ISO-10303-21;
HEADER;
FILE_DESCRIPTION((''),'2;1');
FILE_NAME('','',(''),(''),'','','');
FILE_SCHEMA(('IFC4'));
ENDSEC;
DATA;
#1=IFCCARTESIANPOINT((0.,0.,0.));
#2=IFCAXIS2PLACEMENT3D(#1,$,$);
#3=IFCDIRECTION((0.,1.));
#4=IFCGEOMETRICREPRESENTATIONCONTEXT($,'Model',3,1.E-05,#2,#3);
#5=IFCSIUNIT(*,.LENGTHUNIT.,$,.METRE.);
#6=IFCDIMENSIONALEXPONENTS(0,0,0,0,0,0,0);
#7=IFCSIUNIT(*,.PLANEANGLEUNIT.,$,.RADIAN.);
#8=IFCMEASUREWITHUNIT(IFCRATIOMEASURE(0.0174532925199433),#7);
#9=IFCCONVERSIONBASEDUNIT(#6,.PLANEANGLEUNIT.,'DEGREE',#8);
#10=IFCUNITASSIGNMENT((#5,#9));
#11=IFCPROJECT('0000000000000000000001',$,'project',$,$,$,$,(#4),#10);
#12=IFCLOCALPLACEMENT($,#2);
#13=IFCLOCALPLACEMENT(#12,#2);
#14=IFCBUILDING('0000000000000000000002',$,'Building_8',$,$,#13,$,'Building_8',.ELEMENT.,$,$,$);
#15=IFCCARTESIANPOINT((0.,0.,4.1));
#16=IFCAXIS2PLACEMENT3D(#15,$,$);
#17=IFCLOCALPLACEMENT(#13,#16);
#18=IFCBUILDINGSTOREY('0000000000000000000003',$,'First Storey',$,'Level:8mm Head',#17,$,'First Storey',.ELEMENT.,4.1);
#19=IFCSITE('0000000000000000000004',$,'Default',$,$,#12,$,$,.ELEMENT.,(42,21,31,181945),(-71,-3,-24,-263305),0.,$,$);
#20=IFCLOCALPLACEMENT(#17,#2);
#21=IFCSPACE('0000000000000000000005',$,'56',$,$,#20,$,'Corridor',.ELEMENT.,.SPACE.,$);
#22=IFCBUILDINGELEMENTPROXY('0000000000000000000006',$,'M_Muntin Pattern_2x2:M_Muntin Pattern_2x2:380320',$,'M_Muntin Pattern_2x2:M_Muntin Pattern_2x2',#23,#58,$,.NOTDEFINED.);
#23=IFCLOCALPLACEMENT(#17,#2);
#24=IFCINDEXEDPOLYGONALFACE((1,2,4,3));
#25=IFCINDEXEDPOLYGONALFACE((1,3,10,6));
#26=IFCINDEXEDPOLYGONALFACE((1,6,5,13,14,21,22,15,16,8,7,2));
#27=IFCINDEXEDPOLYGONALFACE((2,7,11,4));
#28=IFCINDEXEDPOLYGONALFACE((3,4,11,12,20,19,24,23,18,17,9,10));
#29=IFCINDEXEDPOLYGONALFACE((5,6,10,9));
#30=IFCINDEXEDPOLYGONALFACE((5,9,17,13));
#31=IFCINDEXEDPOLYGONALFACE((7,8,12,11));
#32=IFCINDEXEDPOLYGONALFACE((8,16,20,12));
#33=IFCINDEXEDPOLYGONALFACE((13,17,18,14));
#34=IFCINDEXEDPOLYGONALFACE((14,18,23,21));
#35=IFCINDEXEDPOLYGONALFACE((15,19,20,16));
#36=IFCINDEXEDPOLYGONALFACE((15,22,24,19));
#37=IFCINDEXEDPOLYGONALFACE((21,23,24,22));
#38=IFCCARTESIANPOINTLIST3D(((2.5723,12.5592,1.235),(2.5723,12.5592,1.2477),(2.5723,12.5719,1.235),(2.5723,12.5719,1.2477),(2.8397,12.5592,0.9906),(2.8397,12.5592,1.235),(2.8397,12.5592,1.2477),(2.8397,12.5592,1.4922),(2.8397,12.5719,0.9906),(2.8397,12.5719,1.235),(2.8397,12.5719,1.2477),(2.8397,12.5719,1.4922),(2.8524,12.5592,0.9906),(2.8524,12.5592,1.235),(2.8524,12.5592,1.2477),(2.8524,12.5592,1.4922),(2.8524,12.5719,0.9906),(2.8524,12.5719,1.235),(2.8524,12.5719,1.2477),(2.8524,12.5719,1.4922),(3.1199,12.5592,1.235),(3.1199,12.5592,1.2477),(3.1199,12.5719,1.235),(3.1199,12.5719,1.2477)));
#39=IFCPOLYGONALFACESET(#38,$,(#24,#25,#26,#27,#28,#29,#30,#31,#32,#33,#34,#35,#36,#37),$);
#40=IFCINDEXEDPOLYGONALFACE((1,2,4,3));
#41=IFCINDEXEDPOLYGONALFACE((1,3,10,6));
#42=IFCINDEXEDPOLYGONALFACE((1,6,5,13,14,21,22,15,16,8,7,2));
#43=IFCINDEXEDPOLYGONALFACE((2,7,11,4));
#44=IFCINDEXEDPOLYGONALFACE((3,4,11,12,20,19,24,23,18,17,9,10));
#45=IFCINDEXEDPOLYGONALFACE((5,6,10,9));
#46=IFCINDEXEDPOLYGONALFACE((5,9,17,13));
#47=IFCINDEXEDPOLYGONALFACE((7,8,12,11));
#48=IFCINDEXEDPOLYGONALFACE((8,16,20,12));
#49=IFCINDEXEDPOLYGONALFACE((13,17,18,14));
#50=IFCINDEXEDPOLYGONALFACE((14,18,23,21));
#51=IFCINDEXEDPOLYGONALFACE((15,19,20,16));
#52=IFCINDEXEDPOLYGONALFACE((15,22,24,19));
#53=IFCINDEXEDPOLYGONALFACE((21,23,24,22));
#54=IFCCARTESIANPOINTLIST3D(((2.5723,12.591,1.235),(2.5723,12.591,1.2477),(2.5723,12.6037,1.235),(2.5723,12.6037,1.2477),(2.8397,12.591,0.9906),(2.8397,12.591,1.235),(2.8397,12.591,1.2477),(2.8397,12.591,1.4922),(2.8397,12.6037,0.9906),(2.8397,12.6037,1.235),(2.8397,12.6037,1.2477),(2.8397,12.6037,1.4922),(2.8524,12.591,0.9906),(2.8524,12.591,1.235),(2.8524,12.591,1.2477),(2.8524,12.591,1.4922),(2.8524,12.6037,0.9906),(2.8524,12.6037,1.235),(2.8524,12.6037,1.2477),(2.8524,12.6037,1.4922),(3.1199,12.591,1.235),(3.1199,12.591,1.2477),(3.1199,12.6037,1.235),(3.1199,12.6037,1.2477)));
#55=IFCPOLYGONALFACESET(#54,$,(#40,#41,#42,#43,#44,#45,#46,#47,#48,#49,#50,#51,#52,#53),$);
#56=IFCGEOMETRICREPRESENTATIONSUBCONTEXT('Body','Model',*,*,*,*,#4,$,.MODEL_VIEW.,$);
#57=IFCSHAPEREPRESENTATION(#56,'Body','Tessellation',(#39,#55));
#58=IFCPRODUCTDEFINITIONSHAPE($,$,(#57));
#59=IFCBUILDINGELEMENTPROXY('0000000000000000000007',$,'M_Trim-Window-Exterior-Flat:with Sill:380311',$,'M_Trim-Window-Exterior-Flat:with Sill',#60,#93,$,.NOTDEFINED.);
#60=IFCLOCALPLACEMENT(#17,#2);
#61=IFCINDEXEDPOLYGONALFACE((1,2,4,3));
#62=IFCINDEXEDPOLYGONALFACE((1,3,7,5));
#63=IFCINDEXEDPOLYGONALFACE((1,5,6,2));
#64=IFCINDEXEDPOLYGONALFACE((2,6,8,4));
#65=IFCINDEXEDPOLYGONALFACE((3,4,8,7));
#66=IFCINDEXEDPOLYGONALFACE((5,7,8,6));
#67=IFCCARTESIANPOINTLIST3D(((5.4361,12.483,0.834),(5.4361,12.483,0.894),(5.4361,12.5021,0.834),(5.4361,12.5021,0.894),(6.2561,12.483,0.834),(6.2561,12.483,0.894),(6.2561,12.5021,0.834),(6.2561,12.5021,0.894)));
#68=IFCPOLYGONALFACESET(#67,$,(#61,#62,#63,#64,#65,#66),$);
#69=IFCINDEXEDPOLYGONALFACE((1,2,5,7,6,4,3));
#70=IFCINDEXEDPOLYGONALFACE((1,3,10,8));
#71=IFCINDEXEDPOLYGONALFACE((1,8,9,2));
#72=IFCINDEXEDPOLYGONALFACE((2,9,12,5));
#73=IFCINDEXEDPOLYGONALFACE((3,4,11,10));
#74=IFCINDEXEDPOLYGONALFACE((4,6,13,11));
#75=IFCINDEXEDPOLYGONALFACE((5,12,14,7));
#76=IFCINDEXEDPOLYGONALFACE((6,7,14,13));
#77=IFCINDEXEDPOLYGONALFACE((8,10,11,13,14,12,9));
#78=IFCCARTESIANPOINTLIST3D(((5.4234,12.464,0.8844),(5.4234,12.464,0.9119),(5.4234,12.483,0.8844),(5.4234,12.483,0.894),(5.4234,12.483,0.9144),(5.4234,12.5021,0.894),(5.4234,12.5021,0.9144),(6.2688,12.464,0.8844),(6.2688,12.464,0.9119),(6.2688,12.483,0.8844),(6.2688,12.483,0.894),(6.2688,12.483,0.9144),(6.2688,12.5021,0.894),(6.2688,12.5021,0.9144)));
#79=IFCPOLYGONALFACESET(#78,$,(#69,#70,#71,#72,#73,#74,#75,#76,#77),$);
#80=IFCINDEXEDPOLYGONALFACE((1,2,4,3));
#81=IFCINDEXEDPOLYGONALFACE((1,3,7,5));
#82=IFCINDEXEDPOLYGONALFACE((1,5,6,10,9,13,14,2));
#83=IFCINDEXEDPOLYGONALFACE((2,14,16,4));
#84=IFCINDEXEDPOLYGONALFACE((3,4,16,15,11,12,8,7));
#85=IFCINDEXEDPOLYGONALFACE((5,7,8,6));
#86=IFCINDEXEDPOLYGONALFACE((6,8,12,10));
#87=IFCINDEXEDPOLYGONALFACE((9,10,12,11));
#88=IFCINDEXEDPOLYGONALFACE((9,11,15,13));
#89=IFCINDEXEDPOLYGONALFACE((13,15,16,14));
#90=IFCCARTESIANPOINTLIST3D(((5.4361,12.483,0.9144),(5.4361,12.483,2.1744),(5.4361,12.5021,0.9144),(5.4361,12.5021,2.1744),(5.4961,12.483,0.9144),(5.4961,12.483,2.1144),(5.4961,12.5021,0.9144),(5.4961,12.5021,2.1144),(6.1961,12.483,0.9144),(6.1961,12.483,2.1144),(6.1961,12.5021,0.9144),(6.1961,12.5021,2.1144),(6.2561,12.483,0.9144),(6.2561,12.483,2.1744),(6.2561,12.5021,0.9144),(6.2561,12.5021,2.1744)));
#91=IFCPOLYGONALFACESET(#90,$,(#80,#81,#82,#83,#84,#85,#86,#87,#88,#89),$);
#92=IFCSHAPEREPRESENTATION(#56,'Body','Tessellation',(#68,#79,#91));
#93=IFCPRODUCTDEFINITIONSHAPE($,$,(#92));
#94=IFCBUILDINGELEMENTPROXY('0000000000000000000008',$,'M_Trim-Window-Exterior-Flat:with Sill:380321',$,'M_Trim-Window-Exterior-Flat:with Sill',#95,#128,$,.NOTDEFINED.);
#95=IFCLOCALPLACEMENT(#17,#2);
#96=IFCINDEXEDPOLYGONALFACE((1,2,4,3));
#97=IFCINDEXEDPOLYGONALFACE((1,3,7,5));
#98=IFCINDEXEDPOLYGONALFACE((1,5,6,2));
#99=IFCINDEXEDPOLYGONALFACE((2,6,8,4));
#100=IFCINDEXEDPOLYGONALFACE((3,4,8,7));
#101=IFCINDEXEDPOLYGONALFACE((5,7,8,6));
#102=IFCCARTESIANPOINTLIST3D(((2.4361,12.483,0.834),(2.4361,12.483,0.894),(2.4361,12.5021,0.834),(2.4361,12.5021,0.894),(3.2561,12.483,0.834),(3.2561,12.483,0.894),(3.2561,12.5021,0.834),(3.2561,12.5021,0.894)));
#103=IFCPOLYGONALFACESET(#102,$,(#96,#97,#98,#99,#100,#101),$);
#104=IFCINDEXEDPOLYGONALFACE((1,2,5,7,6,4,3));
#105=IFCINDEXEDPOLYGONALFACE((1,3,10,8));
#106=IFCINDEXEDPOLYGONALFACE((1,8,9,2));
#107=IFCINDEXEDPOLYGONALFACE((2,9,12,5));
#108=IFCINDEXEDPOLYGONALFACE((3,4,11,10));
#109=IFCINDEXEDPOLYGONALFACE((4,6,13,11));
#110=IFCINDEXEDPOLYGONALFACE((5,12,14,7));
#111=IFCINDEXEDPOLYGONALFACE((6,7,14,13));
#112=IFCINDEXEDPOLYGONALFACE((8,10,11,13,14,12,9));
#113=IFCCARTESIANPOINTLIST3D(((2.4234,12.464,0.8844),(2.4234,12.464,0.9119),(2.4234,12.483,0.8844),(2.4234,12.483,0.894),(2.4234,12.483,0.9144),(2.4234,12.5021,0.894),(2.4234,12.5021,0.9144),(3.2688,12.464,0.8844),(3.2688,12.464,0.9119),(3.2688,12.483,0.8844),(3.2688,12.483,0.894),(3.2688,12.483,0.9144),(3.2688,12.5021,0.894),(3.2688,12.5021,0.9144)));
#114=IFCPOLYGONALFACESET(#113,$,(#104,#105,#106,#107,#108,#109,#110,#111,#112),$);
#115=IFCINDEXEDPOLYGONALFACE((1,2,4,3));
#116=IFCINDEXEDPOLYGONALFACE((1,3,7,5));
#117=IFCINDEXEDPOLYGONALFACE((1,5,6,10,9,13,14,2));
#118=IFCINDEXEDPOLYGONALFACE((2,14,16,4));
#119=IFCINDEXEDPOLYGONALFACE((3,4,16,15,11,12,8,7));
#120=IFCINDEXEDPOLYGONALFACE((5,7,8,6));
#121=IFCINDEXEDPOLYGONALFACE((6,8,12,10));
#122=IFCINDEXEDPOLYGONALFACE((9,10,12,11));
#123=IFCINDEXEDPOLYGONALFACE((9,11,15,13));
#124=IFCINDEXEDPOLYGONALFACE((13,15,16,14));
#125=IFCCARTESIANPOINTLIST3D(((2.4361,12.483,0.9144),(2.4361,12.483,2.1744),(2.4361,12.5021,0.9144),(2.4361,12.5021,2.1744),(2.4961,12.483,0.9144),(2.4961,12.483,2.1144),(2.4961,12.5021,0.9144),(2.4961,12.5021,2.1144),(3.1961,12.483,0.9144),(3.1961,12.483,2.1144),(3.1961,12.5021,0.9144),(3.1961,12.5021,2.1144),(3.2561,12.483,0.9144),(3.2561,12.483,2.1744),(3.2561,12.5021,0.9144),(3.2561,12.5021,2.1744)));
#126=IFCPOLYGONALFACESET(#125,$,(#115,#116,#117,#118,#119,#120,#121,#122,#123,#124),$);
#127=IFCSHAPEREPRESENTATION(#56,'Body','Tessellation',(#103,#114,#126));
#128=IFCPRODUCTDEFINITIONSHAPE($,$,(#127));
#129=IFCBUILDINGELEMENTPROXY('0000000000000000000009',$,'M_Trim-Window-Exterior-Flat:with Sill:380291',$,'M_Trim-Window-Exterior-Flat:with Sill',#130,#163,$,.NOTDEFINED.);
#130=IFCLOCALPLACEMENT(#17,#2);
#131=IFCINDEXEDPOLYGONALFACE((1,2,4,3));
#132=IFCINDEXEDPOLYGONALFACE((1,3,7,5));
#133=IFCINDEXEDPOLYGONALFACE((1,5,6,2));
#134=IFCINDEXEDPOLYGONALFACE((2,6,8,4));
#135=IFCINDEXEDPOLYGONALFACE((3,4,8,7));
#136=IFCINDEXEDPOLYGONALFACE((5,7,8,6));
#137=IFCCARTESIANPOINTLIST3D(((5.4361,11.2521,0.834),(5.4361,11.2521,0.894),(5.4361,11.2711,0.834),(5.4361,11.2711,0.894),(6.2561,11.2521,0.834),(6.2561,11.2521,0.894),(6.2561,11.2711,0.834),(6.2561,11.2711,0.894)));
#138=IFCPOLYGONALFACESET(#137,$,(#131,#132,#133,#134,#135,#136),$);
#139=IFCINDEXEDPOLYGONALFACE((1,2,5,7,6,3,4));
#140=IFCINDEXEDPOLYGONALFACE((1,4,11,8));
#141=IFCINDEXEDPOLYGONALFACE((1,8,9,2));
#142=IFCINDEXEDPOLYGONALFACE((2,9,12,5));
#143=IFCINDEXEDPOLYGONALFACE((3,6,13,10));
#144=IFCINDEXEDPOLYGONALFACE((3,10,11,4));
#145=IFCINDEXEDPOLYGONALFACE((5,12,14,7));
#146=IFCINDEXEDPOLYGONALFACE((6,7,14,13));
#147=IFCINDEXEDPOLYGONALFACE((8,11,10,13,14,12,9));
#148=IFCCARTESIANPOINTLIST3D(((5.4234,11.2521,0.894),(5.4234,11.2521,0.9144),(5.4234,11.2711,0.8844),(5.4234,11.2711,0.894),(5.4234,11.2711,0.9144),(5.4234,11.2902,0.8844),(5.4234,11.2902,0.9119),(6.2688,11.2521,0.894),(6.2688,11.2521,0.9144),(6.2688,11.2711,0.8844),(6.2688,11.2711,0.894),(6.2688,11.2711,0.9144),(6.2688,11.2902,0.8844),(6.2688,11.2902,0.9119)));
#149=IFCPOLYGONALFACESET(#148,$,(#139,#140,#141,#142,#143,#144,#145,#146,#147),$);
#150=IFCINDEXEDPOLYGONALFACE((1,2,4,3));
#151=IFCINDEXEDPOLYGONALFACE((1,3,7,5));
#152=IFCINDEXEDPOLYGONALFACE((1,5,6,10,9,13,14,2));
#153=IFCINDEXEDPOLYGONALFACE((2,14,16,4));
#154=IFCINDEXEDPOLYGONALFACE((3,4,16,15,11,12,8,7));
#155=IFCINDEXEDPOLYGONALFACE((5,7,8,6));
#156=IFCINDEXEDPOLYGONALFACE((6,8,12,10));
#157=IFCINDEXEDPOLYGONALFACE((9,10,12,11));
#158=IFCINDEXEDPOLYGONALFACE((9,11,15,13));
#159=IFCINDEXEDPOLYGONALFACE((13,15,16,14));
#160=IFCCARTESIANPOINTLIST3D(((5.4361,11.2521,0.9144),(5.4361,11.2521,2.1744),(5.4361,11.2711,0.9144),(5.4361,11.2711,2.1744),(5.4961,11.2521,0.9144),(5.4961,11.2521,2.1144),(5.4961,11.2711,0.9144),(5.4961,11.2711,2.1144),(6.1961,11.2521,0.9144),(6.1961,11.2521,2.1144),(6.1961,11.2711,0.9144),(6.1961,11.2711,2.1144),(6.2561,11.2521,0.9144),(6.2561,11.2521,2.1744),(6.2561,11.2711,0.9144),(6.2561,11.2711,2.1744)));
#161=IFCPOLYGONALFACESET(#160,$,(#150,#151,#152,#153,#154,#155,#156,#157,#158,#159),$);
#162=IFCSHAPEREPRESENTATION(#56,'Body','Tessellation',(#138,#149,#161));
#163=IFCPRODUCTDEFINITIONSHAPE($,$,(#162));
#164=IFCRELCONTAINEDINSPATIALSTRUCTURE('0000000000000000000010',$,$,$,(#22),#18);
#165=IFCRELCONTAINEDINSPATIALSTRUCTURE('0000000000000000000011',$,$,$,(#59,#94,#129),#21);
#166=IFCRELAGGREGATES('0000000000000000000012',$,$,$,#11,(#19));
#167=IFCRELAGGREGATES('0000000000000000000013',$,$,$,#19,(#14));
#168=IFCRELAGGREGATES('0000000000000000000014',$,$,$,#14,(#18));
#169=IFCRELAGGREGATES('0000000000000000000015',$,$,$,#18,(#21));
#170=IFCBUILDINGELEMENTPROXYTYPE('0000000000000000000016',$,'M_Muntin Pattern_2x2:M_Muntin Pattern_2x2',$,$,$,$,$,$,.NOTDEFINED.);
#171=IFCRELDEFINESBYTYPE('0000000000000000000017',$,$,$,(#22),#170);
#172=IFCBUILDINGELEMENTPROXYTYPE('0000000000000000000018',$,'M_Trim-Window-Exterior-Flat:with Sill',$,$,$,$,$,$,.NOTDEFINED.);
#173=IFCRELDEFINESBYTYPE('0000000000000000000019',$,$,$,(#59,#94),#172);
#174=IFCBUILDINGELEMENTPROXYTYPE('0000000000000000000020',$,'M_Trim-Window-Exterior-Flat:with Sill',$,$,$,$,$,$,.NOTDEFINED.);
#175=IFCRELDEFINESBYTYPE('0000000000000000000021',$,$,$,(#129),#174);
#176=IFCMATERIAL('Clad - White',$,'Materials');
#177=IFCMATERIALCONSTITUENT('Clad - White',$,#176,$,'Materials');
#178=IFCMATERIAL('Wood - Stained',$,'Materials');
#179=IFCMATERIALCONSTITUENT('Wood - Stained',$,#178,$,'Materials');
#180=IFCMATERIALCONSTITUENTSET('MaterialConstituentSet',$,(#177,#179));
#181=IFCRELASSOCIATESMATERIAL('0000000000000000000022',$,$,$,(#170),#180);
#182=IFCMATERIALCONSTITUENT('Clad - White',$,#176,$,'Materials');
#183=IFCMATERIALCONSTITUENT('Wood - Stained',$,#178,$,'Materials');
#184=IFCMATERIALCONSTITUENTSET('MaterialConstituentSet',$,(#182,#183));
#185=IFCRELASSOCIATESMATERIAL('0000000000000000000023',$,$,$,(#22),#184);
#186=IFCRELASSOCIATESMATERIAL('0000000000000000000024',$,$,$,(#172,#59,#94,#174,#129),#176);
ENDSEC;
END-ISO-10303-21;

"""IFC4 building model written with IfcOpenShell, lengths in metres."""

from ifc_helpers import new_model, entity, si_unit, converted_unit, direction, frame, origin, place, context, subcontext, project, spatial, indexed_curve, outline, extrude, source, transform, mapped, material, constituent, constituent_set, type_object, type_shapes, element, save


model = new_model("IFC4")

# Units and contexts
model_context = context("Model", 3, precision=1e-05, world=origin(), true_north=direction((0.0, 1.0)))
body_context = subcontext(model_context, "Body", "Model", "MODEL_VIEW")
ifc_project = project(units=[si_unit("LENGTHUNIT", "METRE"), converted_unit("PLANEANGLEUNIT", "DEGREE", entity("IfcRatioMeasure", 0.0174532925199433), si_unit("PLANEANGLEUNIT", "RADIAN"), dimensions=[0, 0, 0, 0, 0, 0, 0])], contexts=[model_context])

# Site, building, storey
site_placement = place(None, origin())
site = spatial("IfcSite", under=ifc_project, at=site_placement, Name="Default", CompositionType="ELEMENT", RefLatitude=(42, 21, 31, 181945), RefLongitude=(-71, -3, -24, -263305), RefElevation=0.0)
building_placement = place(site_placement, origin())
building = spatial("IfcBuilding", under=site, at=building_placement, Name="Building_8", LongName="Building_8", CompositionType="ELEMENT")
storey_placement = place(building_placement, frame((0.0, 0.0, 4.1)))
storey = spatial("IfcBuildingStorey", under=building, at=storey_placement, Name="First Storey", ObjectType="Level:8mm Head", LongName="First Storey", CompositionType="ELEMENT", Elevation=4.1)

# Building element proxy
ifc_material_1 = material(Name="Clad - White", Category="Materials")
ifc_material_2 = material(Name="Wood - Stained", Category="Materials")
ifc_constituent_1 = constituent(ifc_material_1, Name="Clad - White", Category="Materials")
ifc_constituent_2 = constituent(ifc_material_2, Name="Wood - Stained", Category="Materials")
ifc_constituent_set_1 = constituent_set(constituents=[ifc_constituent_1, ifc_constituent_2], Name="MaterialConstituentSet")
building_element_proxy_type_1 = type_object("IfcBuildingElementProxyType", Name="M_Muntin Pattern_2x2:M_Muntin Pattern_2x2", PredefinedType="NOTDEFINED", material=ifc_constituent_set_1)
shared_shape_1 = source(origin(), body_context, "Body", "SweptSolid", [
    extrude(outline(indexed_curve([(0.0064, -0.0064), (0.2508, -0.0064), (0.2508, 0.0063), (0.0064, 0.0063), (0.0064, 0.2738), (-0.0063, 0.2738), (-0.0063, 0.0063), (-0.2508, 0.0063), (-0.2508, -0.0064), (-0.0063, -0.0064), (-0.0063, -0.2738), (0.0064, -0.2738), (0.0064, -0.0064)], self_intersect=False)), frame((0.0, -0.0222, 0.2508), z_axis=(0.0, 1.0, 0.0), x_axis=(0.0, 0.0, 1.0)), (0.0, 0.0, 1.0), 0.0127),
    extrude(outline(indexed_curve([(0.0064, -0.0064), (0.2508, -0.0064), (0.2508, 0.0063), (0.0064, 0.0063), (0.0064, 0.2738), (-0.0063, 0.2738), (-0.0063, 0.0063), (-0.2508, 0.0063), (-0.2508, -0.0064), (-0.0063, -0.0064), (-0.0063, -0.2738), (0.0064, -0.2738), (0.0064, -0.0064)], self_intersect=False)), frame((0.0, 0.0095, 0.2508), z_axis=(0.0, 1.0, 0.0), x_axis=(0.0, 0.0, 1.0)), (0.0, 0.0, 1.0), 0.0127),
])
type_shapes(building_element_proxy_type_1, [shared_shape_1])
ifc_constituent_3 = constituent(ifc_material_1, Name="Clad - White", Category="Materials")
ifc_constituent_4 = constituent(ifc_material_2, Name="Wood - Stained", Category="Materials")
ifc_constituent_set_2 = constituent_set(constituents=[ifc_constituent_3, ifc_constituent_4], Name="MaterialConstituentSet")
proxy_1_placement = place(storey_placement, frame((2.8461, 12.5814, 0.9906)))
element("IfcBuildingElementProxy", 1, at=proxy_1_placement, inside=storey, type_object=building_element_proxy_type_1, material=ifc_constituent_set_2, Name="M_Muntin Pattern_2x2:M_Muntin Pattern_2x2:380320", ObjectType="M_Muntin Pattern_2x2:M_Muntin Pattern_2x2", PredefinedType="NOTDEFINED", context=body_context, shape_type="MappedRepresentation", body=[
    mapped(shared_shape_1, transform((0.0, 0.0, 0.0), scale=1.0)),
])

# Shared definitions
space_1_placement = place(storey_placement, origin())
space_1 = spatial("IfcSpace", under=storey, at=space_1_placement, Name="56", LongName="Corridor", CompositionType="ELEMENT", PredefinedType="SPACE")

# Building element proxies
building_element_proxy_type_2 = type_object("IfcBuildingElementProxyType", Name="M_Trim-Window-Exterior-Flat:with Sill", PredefinedType="NOTDEFINED", material=ifc_material_1)
shared_shape_2 = source(origin(), body_context, "Body", "SweptSolid", [
    extrude(outline(indexed_curve([(-0.03, -0.41), (0.03, -0.41), (0.03, 0.41), (-0.03, 0.41), (-0.03, -0.41)], self_intersect=False)), frame((0.0, 1.2504, 0.0), z_axis=(0.0, 0.0, 1.0), x_axis=(0.0, 1.0, 0.0)), (0.0, 0.0, 1.0), 0.0191),
    extrude(outline(indexed_curve([(-0.0152, -0.019), (0.0123, -0.019), (0.0148, 0.0), (0.0148, 0.019), (-0.0057, 0.019), (-0.0057, 0.0), (-0.0152, 0.0), (-0.0152, -0.019)], self_intersect=False)), frame((-0.4227, 1.2148, 0.019), z_axis=(1.0, 0.0, 0.0), x_axis=(0.0, -1.0, 0.0)), (0.0, 0.0, 1.0), 0.8454),
    extrude(outline(indexed_curve([(-0.41, -0.645), (0.41, -0.645), (0.41, 0.615), (0.35, 0.615), (0.35, -0.585), (-0.35, -0.585), (-0.35, 0.615), (-0.41, 0.615), (-0.41, -0.645)], self_intersect=False)), frame((0.0, 0.585, 0.0)), (0.0, 0.0, 1.0), 0.0191),
])
type_shapes(building_element_proxy_type_2, [shared_shape_2])
for number, where, z_axis, x_axis, name in (
    (2, (5.8461, 12.5021, 2.1144), (0.0, -1.0, 0.0), (-1.0, 0.0, 0.0), "M_Trim-Window-Exterior-Flat:with Sill:380311"),
    (3, (2.8461, 12.5021, 2.1144), (0.0, -1.0, 0.0), (-1.0, 0.0, 0.0), "M_Trim-Window-Exterior-Flat:with Sill:380321"),
):
    element("IfcBuildingElementProxy", number, at=place(space_1_placement, frame(where, z_axis=z_axis, x_axis=x_axis)), inside=space_1, type_object=building_element_proxy_type_2, material=ifc_material_1, Name=name, ObjectType="M_Trim-Window-Exterior-Flat:with Sill", PredefinedType="NOTDEFINED", context=body_context, shape_type="MappedRepresentation", body=[
        mapped(shared_shape_2, transform((0.0, 0.0, 0.0), scale=1.0)),
    ])
building_element_proxy_type_3 = type_object("IfcBuildingElementProxyType", Name="M_Trim-Window-Exterior-Flat:with Sill", PredefinedType="NOTDEFINED", material=ifc_material_1)
shared_shape_3 = source(origin(), body_context, "Body", "SweptSolid", [
    extrude(outline(indexed_curve([(-0.41, -0.03), (0.41, -0.03), (0.41, 0.03), (-0.41, 0.03), (-0.41, -0.03)], self_intersect=False)), frame((0.0, -1.2504, 0.0), z_axis=(0.0, 0.0, 1.0), x_axis=(-1.0, 0.0, 0.0)), (0.0, 0.0, 1.0), 0.0191),
    extrude(outline(indexed_curve([(-0.019, -0.0152), (0.0, -0.0152), (0.0, -0.0057), (0.019, -0.0057), (0.019, 0.0148), (0.0, 0.0148), (-0.019, 0.0123), (-0.019, -0.0152)], self_intersect=False)), frame((-0.4227, -1.2148, 0.019), z_axis=(1.0, 0.0, 0.0), x_axis=(0.0, 0.0, -1.0)), (0.0, 0.0, 1.0), 0.8454),
    extrude(outline(indexed_curve([(-0.645, -0.41), (0.615, -0.41), (0.615, -0.35), (-0.585, -0.35), (-0.585, 0.35), (0.615, 0.35), (0.615, 0.41), (-0.645, 0.41), (-0.645, -0.41)], self_intersect=False)), frame((0.0, -0.585, 0.0), z_axis=(0.0, 0.0, 1.0), x_axis=(0.0, -1.0, 0.0)), (0.0, 0.0, 1.0), 0.0191),
])
type_shapes(building_element_proxy_type_3, [shared_shape_3])
proxy_2_placement = place(space_1_placement, frame((5.8461, 11.2521, 2.1144), z_axis=(0.0, 1.0, 0.0), x_axis=(-1.0, 0.0, 0.0)))
element("IfcBuildingElementProxy", 4, at=proxy_2_placement, inside=space_1, type_object=building_element_proxy_type_3, material=ifc_material_1, Name="M_Trim-Window-Exterior-Flat:with Sill:380291", ObjectType="M_Trim-Window-Exterior-Flat:with Sill", PredefinedType="NOTDEFINED", context=body_context, shape_type="MappedRepresentation", body=[
    mapped(shared_shape_3, transform((0.0, 0.0, 0.0), scale=1.0)),
])

save(model, "model.ifc")
